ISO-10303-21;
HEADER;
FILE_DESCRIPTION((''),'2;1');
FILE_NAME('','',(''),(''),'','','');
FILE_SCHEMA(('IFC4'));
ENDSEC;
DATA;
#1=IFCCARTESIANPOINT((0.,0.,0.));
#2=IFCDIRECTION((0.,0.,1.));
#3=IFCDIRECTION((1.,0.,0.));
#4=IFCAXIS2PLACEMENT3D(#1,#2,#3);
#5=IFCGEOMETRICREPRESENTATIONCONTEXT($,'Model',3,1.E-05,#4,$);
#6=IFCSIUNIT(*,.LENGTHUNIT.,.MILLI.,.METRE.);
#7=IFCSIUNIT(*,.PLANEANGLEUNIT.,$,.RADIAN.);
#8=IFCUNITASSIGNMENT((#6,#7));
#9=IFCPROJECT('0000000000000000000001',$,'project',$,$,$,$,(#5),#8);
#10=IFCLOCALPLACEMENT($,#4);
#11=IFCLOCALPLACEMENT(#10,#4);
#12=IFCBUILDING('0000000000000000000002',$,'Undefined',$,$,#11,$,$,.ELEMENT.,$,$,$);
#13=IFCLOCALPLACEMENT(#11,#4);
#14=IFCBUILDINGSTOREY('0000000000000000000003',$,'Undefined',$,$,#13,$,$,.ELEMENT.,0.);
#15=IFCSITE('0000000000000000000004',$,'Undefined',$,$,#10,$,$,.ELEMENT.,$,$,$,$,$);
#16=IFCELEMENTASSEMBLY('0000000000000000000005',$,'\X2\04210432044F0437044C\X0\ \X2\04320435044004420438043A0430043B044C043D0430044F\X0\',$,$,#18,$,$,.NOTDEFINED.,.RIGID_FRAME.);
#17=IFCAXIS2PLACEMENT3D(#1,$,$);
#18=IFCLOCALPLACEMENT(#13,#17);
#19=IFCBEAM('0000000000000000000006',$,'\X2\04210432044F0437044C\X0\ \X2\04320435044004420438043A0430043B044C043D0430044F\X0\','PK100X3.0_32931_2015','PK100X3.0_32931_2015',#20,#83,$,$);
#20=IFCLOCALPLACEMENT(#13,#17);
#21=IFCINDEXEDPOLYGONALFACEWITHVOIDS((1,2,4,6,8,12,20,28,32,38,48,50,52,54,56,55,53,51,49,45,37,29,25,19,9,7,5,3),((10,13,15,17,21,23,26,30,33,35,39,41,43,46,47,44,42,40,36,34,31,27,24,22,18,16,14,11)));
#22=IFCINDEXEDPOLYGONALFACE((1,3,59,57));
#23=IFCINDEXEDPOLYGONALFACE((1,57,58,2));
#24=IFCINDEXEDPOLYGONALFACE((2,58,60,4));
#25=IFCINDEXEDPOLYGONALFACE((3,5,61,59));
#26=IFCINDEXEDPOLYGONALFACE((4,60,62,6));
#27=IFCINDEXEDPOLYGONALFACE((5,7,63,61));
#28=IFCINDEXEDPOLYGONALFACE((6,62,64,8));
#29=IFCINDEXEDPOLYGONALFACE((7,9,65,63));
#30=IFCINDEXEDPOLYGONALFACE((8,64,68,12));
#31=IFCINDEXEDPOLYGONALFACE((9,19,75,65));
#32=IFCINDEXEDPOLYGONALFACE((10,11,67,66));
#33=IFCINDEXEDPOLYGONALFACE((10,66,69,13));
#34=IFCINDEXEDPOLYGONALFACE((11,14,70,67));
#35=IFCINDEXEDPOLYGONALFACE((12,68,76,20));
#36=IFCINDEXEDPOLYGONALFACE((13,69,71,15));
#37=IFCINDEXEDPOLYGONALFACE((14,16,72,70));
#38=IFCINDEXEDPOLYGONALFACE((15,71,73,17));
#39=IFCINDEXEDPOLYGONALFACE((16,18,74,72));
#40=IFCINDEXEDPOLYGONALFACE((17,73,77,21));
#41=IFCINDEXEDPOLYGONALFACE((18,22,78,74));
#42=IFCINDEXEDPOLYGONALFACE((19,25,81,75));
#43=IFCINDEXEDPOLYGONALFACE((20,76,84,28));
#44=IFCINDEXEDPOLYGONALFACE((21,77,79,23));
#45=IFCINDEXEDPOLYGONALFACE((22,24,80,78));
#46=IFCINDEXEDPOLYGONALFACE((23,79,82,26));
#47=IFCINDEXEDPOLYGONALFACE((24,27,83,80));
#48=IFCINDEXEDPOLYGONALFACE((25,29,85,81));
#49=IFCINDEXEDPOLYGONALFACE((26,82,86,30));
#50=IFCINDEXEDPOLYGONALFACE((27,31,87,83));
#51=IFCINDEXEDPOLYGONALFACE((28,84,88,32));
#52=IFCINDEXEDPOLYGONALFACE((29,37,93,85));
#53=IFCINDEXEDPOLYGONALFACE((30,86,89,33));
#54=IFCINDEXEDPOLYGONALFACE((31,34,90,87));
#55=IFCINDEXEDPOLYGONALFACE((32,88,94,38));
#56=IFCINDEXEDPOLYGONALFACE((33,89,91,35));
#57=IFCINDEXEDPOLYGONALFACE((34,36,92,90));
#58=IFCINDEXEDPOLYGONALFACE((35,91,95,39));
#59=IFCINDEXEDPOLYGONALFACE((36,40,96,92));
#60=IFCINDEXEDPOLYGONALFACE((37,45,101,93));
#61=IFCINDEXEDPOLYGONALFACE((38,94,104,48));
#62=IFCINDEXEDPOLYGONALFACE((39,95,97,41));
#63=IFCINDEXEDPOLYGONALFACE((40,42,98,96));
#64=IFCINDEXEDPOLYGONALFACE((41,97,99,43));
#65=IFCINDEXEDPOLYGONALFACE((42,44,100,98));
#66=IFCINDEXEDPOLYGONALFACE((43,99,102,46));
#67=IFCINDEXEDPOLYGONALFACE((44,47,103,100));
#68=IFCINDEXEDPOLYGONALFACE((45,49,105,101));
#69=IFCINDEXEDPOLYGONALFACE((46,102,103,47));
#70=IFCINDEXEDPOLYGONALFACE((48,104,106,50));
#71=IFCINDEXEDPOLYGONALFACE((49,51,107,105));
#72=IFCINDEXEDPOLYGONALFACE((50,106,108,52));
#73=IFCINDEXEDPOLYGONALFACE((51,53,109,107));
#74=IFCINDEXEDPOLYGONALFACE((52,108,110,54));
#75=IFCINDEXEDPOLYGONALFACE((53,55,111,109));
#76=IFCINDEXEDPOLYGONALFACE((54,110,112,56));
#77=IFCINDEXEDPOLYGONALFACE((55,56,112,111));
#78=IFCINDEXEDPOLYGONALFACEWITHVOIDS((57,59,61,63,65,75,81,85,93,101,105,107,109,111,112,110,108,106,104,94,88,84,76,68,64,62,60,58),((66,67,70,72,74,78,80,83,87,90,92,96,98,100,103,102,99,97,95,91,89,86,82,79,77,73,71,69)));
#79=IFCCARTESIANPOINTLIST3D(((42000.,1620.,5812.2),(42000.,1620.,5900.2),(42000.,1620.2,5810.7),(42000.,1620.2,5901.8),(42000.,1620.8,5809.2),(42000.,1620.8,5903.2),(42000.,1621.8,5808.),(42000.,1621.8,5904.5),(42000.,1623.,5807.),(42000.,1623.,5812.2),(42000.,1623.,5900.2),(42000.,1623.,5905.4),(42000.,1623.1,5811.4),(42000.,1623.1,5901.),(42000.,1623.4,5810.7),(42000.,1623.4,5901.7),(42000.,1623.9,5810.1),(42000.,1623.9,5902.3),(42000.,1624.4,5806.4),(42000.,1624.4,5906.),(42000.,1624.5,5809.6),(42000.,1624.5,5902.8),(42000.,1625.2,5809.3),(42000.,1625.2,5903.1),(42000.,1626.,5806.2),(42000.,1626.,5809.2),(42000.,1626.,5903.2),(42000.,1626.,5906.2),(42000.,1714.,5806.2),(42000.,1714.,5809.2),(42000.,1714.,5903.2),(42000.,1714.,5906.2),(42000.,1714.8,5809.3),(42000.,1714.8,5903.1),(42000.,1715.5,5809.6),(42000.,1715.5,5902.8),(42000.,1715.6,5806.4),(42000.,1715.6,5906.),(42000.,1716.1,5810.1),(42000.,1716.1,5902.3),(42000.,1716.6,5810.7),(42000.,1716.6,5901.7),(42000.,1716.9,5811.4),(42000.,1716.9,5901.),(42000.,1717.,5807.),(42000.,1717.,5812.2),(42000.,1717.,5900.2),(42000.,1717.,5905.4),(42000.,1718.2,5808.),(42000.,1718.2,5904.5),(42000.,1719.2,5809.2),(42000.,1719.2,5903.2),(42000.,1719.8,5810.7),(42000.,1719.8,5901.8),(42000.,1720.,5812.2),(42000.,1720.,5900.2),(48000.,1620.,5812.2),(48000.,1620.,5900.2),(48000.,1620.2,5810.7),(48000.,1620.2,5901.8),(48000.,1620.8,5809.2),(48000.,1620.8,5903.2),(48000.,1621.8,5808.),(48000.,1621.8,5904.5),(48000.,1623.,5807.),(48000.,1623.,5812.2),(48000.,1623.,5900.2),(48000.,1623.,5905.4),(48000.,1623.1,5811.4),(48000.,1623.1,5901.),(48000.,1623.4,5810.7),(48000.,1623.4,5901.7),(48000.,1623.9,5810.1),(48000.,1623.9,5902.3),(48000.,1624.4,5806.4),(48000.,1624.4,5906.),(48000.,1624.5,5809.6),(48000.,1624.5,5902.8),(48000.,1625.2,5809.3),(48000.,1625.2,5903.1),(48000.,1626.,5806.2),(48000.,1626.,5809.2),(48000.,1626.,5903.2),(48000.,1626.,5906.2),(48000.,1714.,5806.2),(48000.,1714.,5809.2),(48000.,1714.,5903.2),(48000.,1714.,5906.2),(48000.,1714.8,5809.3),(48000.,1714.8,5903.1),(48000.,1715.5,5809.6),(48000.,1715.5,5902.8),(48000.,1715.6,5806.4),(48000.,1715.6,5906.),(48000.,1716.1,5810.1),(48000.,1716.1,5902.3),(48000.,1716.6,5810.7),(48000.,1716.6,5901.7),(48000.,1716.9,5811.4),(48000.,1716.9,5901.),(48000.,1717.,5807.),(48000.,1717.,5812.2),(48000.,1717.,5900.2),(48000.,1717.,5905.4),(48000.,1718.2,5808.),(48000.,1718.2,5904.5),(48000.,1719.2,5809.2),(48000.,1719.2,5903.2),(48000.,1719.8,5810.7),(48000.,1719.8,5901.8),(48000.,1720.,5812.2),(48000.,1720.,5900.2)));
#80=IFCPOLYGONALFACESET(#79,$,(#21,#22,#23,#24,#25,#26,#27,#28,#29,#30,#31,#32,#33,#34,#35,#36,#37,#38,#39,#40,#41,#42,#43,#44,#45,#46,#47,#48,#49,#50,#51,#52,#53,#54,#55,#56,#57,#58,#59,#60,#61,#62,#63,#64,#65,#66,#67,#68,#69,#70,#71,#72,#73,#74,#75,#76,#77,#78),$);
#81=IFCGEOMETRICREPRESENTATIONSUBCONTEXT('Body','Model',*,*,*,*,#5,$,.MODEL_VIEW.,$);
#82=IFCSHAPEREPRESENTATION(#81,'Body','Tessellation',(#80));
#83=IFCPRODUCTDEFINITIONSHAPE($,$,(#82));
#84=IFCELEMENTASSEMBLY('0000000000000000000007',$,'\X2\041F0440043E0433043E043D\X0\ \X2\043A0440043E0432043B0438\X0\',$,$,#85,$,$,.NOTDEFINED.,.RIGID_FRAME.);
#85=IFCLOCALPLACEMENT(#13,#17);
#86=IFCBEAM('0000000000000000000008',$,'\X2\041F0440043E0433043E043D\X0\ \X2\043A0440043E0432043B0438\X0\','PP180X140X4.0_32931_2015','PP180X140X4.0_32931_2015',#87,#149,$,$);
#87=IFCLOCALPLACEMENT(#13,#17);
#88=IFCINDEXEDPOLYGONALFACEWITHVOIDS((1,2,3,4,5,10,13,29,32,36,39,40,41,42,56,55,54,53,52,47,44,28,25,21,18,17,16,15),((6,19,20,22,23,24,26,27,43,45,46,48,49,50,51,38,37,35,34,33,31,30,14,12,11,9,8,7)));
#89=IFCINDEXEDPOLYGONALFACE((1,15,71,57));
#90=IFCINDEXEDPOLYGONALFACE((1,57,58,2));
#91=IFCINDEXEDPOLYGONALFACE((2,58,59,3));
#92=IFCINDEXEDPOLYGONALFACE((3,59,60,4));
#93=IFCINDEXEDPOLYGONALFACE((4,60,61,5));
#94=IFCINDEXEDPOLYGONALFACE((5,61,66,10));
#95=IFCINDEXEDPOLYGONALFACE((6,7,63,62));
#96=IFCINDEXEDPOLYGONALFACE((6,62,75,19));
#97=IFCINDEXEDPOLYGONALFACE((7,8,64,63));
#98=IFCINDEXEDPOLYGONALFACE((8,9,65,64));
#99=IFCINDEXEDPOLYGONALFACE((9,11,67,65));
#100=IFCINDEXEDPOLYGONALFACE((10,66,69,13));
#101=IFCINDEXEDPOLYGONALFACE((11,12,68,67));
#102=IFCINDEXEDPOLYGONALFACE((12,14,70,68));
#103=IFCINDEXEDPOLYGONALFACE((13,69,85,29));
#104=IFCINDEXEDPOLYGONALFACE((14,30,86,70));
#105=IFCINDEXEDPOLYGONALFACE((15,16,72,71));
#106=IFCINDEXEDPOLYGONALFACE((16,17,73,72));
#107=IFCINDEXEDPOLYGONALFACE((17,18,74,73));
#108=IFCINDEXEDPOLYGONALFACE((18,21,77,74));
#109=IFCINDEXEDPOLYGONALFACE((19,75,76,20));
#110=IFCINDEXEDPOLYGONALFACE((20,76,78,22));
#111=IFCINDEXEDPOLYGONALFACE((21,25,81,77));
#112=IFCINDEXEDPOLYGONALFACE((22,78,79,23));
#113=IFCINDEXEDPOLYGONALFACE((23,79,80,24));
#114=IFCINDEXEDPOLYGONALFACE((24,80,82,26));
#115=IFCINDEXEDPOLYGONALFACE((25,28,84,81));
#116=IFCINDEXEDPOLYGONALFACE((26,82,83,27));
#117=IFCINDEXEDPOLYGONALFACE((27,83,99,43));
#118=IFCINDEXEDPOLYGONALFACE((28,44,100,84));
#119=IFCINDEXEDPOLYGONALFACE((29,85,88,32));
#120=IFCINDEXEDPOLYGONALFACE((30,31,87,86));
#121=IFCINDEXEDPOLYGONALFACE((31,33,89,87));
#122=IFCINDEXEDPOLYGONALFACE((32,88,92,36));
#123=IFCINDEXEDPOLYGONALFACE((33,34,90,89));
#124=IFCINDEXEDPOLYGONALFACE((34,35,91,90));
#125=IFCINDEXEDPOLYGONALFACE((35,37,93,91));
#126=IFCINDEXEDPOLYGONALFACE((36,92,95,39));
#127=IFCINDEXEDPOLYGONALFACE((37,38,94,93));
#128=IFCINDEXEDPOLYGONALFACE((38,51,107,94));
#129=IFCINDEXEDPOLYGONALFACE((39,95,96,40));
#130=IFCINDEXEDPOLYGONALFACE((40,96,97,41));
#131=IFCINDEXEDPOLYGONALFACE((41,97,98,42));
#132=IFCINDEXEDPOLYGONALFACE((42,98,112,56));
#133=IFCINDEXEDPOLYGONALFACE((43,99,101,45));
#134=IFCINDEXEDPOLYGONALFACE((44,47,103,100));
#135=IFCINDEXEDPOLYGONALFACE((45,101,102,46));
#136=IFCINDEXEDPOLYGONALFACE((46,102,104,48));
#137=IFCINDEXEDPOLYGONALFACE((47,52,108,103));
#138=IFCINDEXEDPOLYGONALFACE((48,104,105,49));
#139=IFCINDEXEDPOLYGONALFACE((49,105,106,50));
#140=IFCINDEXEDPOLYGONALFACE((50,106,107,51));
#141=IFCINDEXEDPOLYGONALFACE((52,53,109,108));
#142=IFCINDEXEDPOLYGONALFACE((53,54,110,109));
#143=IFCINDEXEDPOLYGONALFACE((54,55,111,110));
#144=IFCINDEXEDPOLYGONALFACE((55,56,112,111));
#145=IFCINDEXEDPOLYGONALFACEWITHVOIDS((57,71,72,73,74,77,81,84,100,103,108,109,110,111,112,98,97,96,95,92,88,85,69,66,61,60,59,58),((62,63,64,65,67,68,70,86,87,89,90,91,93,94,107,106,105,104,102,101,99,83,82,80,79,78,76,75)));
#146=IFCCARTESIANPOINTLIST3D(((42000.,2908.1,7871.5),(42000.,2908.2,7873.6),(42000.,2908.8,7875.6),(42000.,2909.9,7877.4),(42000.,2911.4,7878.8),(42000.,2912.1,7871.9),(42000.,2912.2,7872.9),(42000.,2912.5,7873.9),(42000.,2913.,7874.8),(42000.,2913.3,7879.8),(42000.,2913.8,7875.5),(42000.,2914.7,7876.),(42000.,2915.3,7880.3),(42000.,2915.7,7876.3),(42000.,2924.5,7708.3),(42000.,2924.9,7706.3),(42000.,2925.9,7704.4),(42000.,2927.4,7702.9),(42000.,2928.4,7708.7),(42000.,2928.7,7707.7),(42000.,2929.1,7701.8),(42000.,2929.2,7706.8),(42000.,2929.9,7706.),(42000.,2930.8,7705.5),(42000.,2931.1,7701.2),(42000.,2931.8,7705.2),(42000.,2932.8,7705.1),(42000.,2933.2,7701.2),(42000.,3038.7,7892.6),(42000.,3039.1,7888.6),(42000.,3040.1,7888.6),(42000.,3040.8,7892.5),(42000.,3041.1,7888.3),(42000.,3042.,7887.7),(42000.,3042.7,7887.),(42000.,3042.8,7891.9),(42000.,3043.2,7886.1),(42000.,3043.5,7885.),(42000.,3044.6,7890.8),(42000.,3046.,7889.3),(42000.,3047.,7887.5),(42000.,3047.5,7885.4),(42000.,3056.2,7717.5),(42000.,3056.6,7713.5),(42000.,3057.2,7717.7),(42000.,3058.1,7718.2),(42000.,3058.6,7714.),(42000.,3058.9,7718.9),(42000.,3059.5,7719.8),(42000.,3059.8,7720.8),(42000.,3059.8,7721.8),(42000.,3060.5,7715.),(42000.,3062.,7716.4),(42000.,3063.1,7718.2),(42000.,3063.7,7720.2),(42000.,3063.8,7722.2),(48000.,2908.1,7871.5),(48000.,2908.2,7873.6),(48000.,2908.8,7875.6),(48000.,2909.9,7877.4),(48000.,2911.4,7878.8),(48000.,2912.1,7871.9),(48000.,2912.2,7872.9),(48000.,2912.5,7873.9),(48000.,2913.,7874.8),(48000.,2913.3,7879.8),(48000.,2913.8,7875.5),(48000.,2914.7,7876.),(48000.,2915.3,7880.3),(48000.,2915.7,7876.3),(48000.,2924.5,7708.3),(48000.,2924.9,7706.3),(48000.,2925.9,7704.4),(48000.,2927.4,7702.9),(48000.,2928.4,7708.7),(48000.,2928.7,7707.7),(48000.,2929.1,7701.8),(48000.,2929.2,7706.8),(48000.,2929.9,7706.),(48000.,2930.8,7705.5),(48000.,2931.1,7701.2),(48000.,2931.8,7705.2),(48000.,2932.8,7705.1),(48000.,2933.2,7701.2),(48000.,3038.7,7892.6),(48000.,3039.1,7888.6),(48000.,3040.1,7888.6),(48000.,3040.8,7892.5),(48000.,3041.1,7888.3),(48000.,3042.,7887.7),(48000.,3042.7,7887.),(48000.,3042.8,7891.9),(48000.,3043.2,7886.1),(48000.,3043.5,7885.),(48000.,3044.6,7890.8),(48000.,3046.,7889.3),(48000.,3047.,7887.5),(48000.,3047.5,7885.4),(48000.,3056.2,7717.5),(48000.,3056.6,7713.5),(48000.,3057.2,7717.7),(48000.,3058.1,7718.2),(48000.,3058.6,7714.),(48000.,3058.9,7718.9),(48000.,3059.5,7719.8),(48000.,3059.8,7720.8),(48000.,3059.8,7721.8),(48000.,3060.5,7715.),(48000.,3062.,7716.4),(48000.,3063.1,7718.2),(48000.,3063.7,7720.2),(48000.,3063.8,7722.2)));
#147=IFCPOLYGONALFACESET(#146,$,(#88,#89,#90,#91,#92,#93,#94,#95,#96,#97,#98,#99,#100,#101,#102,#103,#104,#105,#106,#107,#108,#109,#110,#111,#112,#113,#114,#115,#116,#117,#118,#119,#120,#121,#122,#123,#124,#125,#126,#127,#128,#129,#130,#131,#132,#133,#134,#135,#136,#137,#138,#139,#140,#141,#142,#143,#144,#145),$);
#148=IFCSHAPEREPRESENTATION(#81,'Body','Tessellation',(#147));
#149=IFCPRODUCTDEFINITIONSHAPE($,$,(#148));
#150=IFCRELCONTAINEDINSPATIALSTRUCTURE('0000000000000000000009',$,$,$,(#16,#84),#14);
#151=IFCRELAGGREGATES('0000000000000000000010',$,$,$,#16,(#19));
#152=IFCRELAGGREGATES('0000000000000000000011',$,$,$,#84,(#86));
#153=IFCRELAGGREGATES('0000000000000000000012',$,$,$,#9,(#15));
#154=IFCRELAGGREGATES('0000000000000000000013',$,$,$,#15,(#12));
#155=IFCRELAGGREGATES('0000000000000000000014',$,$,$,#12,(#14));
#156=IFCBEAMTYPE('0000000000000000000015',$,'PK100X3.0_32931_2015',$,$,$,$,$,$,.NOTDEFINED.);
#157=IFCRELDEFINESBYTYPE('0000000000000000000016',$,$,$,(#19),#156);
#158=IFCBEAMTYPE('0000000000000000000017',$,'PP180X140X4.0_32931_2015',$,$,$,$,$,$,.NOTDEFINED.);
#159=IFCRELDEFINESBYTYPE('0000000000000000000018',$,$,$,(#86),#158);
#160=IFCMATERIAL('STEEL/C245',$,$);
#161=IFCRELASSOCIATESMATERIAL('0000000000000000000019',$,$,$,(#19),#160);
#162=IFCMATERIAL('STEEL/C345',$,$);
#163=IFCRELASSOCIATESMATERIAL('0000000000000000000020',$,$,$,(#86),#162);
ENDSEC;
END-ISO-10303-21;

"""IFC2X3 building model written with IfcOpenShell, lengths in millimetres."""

from ifc_helpers import new_model, si_unit, frame, origin_with_axes, origin_2d_with_axis, place, context, subcontext, project, spatial, hollow_rectangle, extrude, material, type_object, element, aggregate, save


model = new_model("IFC2X3")

# Units and contexts
model_context = context("Model", 3, precision=1e-05, world=origin_with_axes())
body_context = subcontext(model_context, "Body", "Model", "MODEL_VIEW")
ifc_project = project(units=[si_unit("LENGTHUNIT", "METRE", prefix="MILLI"), si_unit("PLANEANGLEUNIT", "RADIAN")], contexts=[model_context])

# Site, building, storey
site_placement = place(None, origin_with_axes())
site = spatial("IfcSite", under=ifc_project, at=site_placement, Name="Undefined", CompositionType="ELEMENT")
building_placement = place(site_placement, origin_with_axes())
building = spatial("IfcBuilding", under=site, at=building_placement, Name="Undefined", CompositionType="ELEMENT")
storey_placement = place(building_placement, origin_with_axes())
storey = spatial("IfcBuildingStorey", under=building, at=storey_placement, Name="Undefined", CompositionType="ELEMENT", Elevation=0.0)

# Element assemblies, beams
assembly_1_placement = place(storey_placement, origin_with_axes())
assembly_1 = element("IfcElementAssembly", 1, at=assembly_1_placement, inside=storey, Name="Связь вертикальная", AssemblyPlace="NOTDEFINED", PredefinedType="RIGID_FRAME")
ifc_material_1 = material(Name="STEEL/C245")
beam_type_1 = type_object("IfcBeamType", Name="PK100X3.0_32931_2015", PredefinedType="NOTDEFINED")
beam_1_placement = place(assembly_1_placement, frame((42000.0, 1670.0, 5856.2), z_axis=(0.0, 0.0, 1.0), x_axis=(1.0, 0.0, 0.0)))
beam_1 = element("IfcBeam", 2, at=beam_1_placement, type_object=beam_type_1, material=ifc_material_1, Name="Связь вертикальная", Description="PK100X3.0_32931_2015", ObjectType="PK100X3.0_32931_2015", context=body_context, shape_type="SweptSolid", body=[
    extrude(hollow_rectangle(XDim=100.0, YDim=100.0, WallThickness=3.0, InnerFilletRadius=3.0, OuterFilletRadius=6.0, at=origin_2d_with_axis()), frame((6000.0, 0.0, 0.0), z_axis=(-1.0, 0.0, 0.0), x_axis=(0.0, -1.0, 0.0)), (0.0, 0.0, 1.0), 6000.0),
])
aggregate(assembly_1, [beam_1])
assembly_2_placement = place(storey_placement, origin_with_axes())
assembly_2 = element("IfcElementAssembly", 3, at=assembly_2_placement, inside=storey, Name="Прогон кровли", AssemblyPlace="NOTDEFINED", PredefinedType="RIGID_FRAME")
ifc_material_2 = material(Name="STEEL/C345")
beam_type_2 = type_object("IfcBeamType", Name="PP180X140X4.0_32931_2015", PredefinedType="NOTDEFINED")
beam_2_placement = place(assembly_2_placement, frame((42000.0, 2986.0, 7796.9), z_axis=(0.0, -0.099504, 0.995037), x_axis=(1.0, 0.0, 0.0)))
beam_2 = element("IfcBeam", 4, at=beam_2_placement, type_object=beam_type_2, material=ifc_material_2, Name="Прогон кровли", Description="PP180X140X4.0_32931_2015", ObjectType="PP180X140X4.0_32931_2015", context=body_context, shape_type="SweptSolid", body=[
    extrude(hollow_rectangle(XDim=140.0, YDim=180.0, WallThickness=4.0, InnerFilletRadius=4.0, OuterFilletRadius=8.0, at=origin_2d_with_axis()), frame((6000.0, 0.0, 0.0), z_axis=(-1.0, 0.0, 0.0), x_axis=(0.0, -1.0, 0.0)), (0.0, 0.0, 1.0), 6000.0),
])
aggregate(assembly_2, [beam_2])

save(model, "model.ifc")
